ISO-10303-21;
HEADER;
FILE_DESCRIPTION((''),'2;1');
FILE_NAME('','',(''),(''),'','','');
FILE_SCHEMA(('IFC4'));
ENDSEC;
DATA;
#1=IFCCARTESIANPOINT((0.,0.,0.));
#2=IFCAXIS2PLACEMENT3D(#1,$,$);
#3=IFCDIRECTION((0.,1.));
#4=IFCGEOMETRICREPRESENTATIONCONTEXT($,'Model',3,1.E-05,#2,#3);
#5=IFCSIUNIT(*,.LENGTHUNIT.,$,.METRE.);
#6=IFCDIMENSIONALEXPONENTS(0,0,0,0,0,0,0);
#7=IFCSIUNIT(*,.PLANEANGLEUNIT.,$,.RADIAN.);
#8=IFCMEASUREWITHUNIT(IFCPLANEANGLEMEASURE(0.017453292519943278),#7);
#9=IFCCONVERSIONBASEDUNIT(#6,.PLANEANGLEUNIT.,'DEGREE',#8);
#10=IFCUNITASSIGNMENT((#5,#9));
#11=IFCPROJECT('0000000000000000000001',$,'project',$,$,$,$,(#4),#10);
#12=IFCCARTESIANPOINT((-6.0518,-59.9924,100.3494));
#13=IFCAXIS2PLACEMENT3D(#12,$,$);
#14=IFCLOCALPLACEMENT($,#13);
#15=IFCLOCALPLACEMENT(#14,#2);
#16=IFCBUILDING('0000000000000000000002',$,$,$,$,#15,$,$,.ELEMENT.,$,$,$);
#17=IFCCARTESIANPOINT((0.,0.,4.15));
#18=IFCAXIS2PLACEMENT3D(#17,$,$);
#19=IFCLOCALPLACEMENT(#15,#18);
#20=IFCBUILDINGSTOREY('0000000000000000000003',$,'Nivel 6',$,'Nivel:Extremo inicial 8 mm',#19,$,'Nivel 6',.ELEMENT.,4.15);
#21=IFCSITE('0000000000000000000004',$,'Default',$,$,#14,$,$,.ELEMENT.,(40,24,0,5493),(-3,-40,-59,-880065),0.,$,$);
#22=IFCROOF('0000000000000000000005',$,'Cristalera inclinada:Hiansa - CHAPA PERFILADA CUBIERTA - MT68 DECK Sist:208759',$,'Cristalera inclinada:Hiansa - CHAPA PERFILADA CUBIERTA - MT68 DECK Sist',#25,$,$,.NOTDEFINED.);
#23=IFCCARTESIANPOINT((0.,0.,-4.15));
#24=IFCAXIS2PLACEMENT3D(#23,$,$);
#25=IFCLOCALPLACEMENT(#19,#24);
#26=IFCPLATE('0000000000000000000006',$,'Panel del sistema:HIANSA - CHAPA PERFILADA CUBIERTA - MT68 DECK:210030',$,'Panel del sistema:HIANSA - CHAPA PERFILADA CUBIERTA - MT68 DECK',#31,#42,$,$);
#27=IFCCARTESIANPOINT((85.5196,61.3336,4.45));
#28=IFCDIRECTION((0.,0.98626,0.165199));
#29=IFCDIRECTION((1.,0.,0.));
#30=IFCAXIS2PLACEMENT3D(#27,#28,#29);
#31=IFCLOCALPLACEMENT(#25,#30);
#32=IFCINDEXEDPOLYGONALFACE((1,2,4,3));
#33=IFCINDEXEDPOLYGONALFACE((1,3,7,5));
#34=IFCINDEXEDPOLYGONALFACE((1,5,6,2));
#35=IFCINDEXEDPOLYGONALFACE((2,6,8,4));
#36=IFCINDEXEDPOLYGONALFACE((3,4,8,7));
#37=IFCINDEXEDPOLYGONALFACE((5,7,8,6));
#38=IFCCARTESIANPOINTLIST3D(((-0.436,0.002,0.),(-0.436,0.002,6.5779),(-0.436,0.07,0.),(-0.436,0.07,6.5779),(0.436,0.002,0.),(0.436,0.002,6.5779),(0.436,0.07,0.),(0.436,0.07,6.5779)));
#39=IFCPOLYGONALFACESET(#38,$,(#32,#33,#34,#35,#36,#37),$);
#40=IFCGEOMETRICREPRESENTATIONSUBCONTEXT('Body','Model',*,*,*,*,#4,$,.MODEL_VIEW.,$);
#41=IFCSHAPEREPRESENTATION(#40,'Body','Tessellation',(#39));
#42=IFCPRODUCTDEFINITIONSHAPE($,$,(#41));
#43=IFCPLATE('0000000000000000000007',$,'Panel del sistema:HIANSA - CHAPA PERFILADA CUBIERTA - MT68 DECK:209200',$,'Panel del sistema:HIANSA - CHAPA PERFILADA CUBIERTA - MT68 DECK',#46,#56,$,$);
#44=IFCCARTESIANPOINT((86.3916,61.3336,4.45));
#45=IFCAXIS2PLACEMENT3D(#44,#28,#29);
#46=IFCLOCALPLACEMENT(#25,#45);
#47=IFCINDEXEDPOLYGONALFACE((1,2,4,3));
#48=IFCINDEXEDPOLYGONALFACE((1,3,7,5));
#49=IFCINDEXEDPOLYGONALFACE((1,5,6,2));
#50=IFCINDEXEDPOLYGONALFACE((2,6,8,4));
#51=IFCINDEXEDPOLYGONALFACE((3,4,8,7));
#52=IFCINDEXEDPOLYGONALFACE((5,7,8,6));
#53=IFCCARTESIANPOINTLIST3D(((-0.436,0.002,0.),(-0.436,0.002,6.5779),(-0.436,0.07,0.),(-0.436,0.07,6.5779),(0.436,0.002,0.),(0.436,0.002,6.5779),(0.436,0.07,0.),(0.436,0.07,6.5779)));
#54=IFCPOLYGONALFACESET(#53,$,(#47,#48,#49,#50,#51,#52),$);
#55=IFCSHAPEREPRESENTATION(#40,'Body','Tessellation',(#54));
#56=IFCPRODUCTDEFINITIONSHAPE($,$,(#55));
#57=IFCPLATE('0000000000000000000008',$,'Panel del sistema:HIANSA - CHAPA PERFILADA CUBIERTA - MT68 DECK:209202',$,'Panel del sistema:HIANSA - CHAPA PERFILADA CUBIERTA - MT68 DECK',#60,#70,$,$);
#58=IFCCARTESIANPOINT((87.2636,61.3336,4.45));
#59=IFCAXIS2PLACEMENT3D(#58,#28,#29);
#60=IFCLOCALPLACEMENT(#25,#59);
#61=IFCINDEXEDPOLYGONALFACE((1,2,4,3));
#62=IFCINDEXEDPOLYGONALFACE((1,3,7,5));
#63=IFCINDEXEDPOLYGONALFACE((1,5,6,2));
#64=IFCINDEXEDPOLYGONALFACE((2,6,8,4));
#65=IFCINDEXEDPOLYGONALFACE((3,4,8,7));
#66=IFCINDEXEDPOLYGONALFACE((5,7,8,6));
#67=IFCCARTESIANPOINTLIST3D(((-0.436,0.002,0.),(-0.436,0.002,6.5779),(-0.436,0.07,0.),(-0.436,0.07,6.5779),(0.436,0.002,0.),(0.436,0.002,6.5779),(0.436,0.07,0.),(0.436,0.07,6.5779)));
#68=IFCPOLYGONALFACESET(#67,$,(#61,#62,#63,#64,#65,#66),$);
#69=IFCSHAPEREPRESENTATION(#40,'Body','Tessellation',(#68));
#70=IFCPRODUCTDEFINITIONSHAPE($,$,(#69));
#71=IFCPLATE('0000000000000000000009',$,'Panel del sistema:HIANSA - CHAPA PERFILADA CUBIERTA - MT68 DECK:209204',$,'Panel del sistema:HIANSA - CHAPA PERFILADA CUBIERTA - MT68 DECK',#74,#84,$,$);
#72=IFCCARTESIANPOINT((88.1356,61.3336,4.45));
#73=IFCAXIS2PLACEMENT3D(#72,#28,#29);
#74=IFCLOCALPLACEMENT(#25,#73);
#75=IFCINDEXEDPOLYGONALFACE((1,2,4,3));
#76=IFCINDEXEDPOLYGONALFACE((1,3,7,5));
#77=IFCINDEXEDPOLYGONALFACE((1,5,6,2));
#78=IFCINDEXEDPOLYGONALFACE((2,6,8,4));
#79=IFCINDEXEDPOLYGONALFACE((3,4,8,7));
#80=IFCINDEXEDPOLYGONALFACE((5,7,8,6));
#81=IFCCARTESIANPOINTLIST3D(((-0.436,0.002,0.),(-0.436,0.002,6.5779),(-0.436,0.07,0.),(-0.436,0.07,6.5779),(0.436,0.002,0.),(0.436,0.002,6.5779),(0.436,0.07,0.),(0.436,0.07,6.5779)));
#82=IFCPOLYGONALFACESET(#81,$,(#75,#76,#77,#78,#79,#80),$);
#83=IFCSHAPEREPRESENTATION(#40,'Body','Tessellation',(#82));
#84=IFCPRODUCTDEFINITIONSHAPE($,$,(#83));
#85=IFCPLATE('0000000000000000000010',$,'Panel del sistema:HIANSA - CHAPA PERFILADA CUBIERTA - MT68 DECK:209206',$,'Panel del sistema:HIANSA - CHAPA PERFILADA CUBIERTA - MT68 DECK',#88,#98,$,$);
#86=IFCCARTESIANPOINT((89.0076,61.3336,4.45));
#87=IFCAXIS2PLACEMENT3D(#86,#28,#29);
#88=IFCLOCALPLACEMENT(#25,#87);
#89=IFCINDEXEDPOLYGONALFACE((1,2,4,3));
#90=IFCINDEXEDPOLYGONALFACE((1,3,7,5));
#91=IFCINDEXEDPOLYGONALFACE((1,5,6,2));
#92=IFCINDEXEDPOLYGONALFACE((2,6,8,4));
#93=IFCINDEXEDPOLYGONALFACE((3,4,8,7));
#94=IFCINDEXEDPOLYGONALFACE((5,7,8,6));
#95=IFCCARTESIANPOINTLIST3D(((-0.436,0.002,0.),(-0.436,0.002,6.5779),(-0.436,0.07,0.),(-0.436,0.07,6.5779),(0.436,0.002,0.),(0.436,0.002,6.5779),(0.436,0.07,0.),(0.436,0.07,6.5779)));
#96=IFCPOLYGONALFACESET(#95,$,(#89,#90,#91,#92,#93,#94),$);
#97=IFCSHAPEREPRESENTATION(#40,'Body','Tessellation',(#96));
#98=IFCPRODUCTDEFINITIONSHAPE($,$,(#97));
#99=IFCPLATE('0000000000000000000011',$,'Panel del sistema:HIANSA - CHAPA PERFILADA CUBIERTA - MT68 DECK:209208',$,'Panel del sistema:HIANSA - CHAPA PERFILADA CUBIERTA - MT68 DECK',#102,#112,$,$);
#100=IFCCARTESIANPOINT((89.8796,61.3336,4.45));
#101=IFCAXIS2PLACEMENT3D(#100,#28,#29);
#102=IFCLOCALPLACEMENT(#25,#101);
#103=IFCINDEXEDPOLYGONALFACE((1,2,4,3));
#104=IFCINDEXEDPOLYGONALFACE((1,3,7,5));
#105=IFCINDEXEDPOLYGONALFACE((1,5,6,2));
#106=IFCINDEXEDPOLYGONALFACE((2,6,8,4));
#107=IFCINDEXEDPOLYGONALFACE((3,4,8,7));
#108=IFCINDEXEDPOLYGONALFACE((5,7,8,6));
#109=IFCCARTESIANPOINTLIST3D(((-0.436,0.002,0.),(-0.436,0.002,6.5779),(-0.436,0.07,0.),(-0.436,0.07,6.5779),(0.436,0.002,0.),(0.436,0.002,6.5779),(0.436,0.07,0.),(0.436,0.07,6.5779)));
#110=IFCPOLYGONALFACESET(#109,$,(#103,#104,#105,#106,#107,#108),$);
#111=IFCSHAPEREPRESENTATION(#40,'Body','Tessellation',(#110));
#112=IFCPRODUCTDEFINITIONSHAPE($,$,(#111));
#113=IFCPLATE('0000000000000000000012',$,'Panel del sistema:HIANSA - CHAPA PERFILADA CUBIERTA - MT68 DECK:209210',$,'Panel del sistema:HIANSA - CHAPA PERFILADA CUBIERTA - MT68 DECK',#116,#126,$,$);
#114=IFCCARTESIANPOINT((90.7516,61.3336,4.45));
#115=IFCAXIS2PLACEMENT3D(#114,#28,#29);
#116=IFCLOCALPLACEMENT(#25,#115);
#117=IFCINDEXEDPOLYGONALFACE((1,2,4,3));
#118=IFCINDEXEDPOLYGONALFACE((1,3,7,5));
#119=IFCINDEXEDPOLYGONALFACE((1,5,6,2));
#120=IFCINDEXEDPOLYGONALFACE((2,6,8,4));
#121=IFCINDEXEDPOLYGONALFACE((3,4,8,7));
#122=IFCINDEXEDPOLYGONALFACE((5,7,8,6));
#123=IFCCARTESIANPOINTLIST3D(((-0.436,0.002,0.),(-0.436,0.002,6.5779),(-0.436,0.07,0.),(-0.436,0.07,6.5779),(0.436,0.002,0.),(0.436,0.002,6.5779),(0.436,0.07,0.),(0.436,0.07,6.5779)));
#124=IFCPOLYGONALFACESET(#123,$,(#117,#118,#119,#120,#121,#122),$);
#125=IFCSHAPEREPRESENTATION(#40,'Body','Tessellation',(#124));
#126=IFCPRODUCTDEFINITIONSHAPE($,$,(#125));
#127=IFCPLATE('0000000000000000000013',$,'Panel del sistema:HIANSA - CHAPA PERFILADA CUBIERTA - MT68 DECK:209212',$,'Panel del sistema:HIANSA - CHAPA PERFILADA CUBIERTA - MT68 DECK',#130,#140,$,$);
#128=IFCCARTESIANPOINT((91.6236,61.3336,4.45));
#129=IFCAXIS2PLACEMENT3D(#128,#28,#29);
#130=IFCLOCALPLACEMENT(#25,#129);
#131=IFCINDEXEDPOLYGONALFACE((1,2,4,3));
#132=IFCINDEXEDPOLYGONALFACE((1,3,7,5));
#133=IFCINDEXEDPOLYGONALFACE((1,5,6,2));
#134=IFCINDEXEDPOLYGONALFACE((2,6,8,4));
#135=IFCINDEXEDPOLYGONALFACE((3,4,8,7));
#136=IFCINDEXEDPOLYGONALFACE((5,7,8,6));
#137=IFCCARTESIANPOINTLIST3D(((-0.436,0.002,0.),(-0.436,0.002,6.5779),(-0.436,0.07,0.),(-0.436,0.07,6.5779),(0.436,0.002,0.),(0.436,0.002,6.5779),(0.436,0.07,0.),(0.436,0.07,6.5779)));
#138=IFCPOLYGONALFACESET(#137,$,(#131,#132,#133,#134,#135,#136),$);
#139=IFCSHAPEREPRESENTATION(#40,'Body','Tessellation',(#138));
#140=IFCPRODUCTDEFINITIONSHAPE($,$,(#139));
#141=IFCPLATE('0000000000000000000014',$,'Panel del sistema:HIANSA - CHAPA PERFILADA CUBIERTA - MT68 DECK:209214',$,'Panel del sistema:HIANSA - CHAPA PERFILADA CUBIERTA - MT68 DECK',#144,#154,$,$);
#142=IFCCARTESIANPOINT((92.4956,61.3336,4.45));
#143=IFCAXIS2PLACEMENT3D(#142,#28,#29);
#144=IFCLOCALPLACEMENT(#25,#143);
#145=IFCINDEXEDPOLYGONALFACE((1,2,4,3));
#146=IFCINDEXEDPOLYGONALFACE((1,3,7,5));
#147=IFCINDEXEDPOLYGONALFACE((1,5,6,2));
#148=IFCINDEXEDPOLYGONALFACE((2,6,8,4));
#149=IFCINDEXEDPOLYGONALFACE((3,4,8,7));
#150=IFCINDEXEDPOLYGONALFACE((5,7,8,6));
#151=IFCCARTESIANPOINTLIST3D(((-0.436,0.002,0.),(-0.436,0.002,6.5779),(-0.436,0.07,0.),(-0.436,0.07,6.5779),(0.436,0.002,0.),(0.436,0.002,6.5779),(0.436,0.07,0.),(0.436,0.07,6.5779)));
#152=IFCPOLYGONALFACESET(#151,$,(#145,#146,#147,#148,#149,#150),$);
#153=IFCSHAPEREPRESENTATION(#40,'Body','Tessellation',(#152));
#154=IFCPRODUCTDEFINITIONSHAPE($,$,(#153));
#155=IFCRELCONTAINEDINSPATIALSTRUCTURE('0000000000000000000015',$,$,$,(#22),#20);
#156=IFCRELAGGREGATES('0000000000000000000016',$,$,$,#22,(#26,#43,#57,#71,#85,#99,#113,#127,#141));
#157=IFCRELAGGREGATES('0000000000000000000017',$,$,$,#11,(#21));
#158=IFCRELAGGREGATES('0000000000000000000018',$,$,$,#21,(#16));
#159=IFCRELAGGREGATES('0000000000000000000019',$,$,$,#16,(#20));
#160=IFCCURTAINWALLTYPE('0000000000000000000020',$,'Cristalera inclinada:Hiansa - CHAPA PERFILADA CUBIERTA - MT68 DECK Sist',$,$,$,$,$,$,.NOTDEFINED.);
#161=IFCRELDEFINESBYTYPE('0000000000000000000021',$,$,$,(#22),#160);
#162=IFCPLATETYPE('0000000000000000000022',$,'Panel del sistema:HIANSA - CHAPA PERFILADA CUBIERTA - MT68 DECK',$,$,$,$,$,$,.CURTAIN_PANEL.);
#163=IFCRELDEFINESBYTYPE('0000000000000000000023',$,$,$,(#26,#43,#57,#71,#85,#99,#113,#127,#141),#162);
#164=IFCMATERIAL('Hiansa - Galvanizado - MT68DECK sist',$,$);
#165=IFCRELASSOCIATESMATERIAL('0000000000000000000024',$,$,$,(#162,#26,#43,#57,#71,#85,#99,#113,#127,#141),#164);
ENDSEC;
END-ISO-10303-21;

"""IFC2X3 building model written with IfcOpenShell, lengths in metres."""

from ifc_helpers import new_model, entity, si_unit, converted_unit, direction, frame, origin, origin_2d_with_axis, place, context, subcontext, project, spatial, rectangle, extrude, source, transform, mapped, material, type_object, type_shapes, element, aggregate, save


model = new_model("IFC2X3")

# Units and contexts
model_context = context("Model", 3, precision=1e-05, world=origin(), true_north=direction((0.0, 1.0)))
body_context = subcontext(model_context, "Body", "Model", "MODEL_VIEW")
ifc_project = project(units=[si_unit("LENGTHUNIT", "METRE"), converted_unit("PLANEANGLEUNIT", "DEGREE", entity("IfcPlaneAngleMeasure", 0.017453292519943278), si_unit("PLANEANGLEUNIT", "RADIAN"), dimensions=[0, 0, 0, 0, 0, 0, 0])], contexts=[model_context])

# Site, building, storey
site_placement = place(None, frame((-6.0518, -59.9924, 100.3494)))
site = spatial("IfcSite", under=ifc_project, at=site_placement, Name="Default", CompositionType="ELEMENT", RefLatitude=(40, 24, 0, 5493), RefLongitude=(-3, -40, -59, -880065), RefElevation=0.0)
building_placement = place(site_placement, origin())
building = spatial("IfcBuilding", under=site, at=building_placement, CompositionType="ELEMENT")
storey_placement = place(building_placement, frame((0.0, 0.0, 4.15)))
storey = spatial("IfcBuildingStorey", under=building, at=storey_placement, Name="Nivel 6", ObjectType="Nivel:Extremo inicial 8 mm", LongName="Nivel 6", CompositionType="ELEMENT", Elevation=4.15)

# Roof, plates
curtain_wall_type = type_object("IfcCurtainWallType", Name="Cristalera inclinada:Hiansa - CHAPA PERFILADA CUBIERTA - MT68 DECK Sist", PredefinedType="NOTDEFINED")
roof_placement = place(storey_placement, frame((0.0, 0.0, -4.15)))
roof = element("IfcRoof", 1, at=roof_placement, inside=storey, type_object=curtain_wall_type, Name="Cristalera inclinada:Hiansa - CHAPA PERFILADA CUBIERTA - MT68 DECK Sist:208759", ObjectType="Cristalera inclinada:Hiansa - CHAPA PERFILADA CUBIERTA - MT68 DECK Sist", ShapeType="NOTDEFINED")
ifc_material_1 = material(Name="Hiansa - Galvanizado - MT68DECK sist")
plate_type_1 = type_object("IfcPlateType", Name="Panel del sistema:HIANSA - CHAPA PERFILADA CUBIERTA - MT68 DECK", PredefinedType="CURTAIN_PANEL", material=ifc_material_1)
shared_shape_1 = source(origin(), body_context, "Body", "SweptSolid", [
    extrude(rectangle(XDim=0.068, YDim=0.872, at=origin_2d_with_axis()), frame((0.0, 0.036, 0.0), z_axis=(0.0, 0.0, 1.0), x_axis=(0.0, 1.0, 0.0)), (0.0, 0.0, 1.0), 6.5779),
])
type_shapes(plate_type_1, [shared_shape_1])
plate_1_placement = place(roof_placement, frame((85.5196, 61.3336, 4.45), z_axis=(0.0, 0.98626, 0.165199), x_axis=(1.0, 0.0, 0.0)))
plate_1 = element("IfcPlate", 2, at=plate_1_placement, type_object=plate_type_1, material=ifc_material_1, Name="Panel del sistema:HIANSA - CHAPA PERFILADA CUBIERTA - MT68 DECK:210030", ObjectType="Panel del sistema:HIANSA - CHAPA PERFILADA CUBIERTA - MT68 DECK", context=body_context, shape_type="MappedRepresentation", body=[
    mapped(shared_shape_1, transform((0.0, 0.0, 0.0), scale=1.0)),
])
plate_2_placement = place(roof_placement, frame((86.3916, 61.3336, 4.45), z_axis=(0.0, 0.98626, 0.165199), x_axis=(1.0, 0.0, 0.0)))
plate_2 = element("IfcPlate", 3, at=plate_2_placement, type_object=plate_type_1, material=ifc_material_1, Name="Panel del sistema:HIANSA - CHAPA PERFILADA CUBIERTA - MT68 DECK:209200", ObjectType="Panel del sistema:HIANSA - CHAPA PERFILADA CUBIERTA - MT68 DECK", context=body_context, shape_type="MappedRepresentation", body=[
    mapped(shared_shape_1, transform((0.0, 0.0, 0.0), scale=1.0)),
])
plate_3_placement = place(roof_placement, frame((87.2636, 61.3336, 4.45), z_axis=(0.0, 0.98626, 0.165199), x_axis=(1.0, 0.0, 0.0)))
plate_3 = element("IfcPlate", 4, at=plate_3_placement, type_object=plate_type_1, material=ifc_material_1, Name="Panel del sistema:HIANSA - CHAPA PERFILADA CUBIERTA - MT68 DECK:209202", ObjectType="Panel del sistema:HIANSA - CHAPA PERFILADA CUBIERTA - MT68 DECK", context=body_context, shape_type="MappedRepresentation", body=[
    mapped(shared_shape_1, transform((0.0, 0.0, 0.0), scale=1.0)),
])
plate_4_placement = place(roof_placement, frame((88.1356, 61.3336, 4.45), z_axis=(0.0, 0.98626, 0.165199), x_axis=(1.0, 0.0, 0.0)))
plate_4 = element("IfcPlate", 5, at=plate_4_placement, type_object=plate_type_1, material=ifc_material_1, Name="Panel del sistema:HIANSA - CHAPA PERFILADA CUBIERTA - MT68 DECK:209204", ObjectType="Panel del sistema:HIANSA - CHAPA PERFILADA CUBIERTA - MT68 DECK", context=body_context, shape_type="MappedRepresentation", body=[
    mapped(shared_shape_1, transform((0.0, 0.0, 0.0), scale=1.0)),
])
plate_5_placement = place(roof_placement, frame((89.0076, 61.3336, 4.45), z_axis=(0.0, 0.98626, 0.165199), x_axis=(1.0, 0.0, 0.0)))
plate_5 = element("IfcPlate", 6, at=plate_5_placement, type_object=plate_type_1, material=ifc_material_1, Name="Panel del sistema:HIANSA - CHAPA PERFILADA CUBIERTA - MT68 DECK:209206", ObjectType="Panel del sistema:HIANSA - CHAPA PERFILADA CUBIERTA - MT68 DECK", context=body_context, shape_type="MappedRepresentation", body=[
    mapped(shared_shape_1, transform((0.0, 0.0, 0.0), scale=1.0)),
])
plate_6_placement = place(roof_placement, frame((89.8796, 61.3336, 4.45), z_axis=(0.0, 0.98626, 0.165199), x_axis=(1.0, 0.0, 0.0)))
plate_6 = element("IfcPlate", 7, at=plate_6_placement, type_object=plate_type_1, material=ifc_material_1, Name="Panel del sistema:HIANSA - CHAPA PERFILADA CUBIERTA - MT68 DECK:209208", ObjectType="Panel del sistema:HIANSA - CHAPA PERFILADA CUBIERTA - MT68 DECK", context=body_context, shape_type="MappedRepresentation", body=[
    mapped(shared_shape_1, transform((0.0, 0.0, 0.0), scale=1.0)),
])
plate_7_placement = place(roof_placement, frame((90.7516, 61.3336, 4.45), z_axis=(0.0, 0.98626, 0.165199), x_axis=(1.0, 0.0, 0.0)))
plate_7 = element("IfcPlate", 8, at=plate_7_placement, type_object=plate_type_1, material=ifc_material_1, Name="Panel del sistema:HIANSA - CHAPA PERFILADA CUBIERTA - MT68 DECK:209210", ObjectType="Panel del sistema:HIANSA - CHAPA PERFILADA CUBIERTA - MT68 DECK", context=body_context, shape_type="MappedRepresentation", body=[
    mapped(shared_shape_1, transform((0.0, 0.0, 0.0), scale=1.0)),
])
plate_8_placement = place(roof_placement, frame((91.6236, 61.3336, 4.45), z_axis=(0.0, 0.98626, 0.165199), x_axis=(1.0, 0.0, 0.0)))
plate_8 = element("IfcPlate", 9, at=plate_8_placement, type_object=plate_type_1, material=ifc_material_1, Name="Panel del sistema:HIANSA - CHAPA PERFILADA CUBIERTA - MT68 DECK:209212", ObjectType="Panel del sistema:HIANSA - CHAPA PERFILADA CUBIERTA - MT68 DECK", context=body_context, shape_type="MappedRepresentation", body=[
    mapped(shared_shape_1, transform((0.0, 0.0, 0.0), scale=1.0)),
])
plate_9_placement = place(roof_placement, frame((92.4956, 61.3336, 4.45), z_axis=(0.0, 0.98626, 0.165199), x_axis=(1.0, 0.0, 0.0)))
plate_9 = element("IfcPlate", 10, at=plate_9_placement, type_object=plate_type_1, material=ifc_material_1, Name="Panel del sistema:HIANSA - CHAPA PERFILADA CUBIERTA - MT68 DECK:209214", ObjectType="Panel del sistema:HIANSA - CHAPA PERFILADA CUBIERTA - MT68 DECK", context=body_context, shape_type="MappedRepresentation", body=[
    mapped(shared_shape_1, transform((0.0, 0.0, 0.0), scale=1.0)),
])
aggregate(roof, [plate_1, plate_2, plate_3, plate_4, plate_5, plate_6, plate_7, plate_8, plate_9])

save(model, "model.ifc")
